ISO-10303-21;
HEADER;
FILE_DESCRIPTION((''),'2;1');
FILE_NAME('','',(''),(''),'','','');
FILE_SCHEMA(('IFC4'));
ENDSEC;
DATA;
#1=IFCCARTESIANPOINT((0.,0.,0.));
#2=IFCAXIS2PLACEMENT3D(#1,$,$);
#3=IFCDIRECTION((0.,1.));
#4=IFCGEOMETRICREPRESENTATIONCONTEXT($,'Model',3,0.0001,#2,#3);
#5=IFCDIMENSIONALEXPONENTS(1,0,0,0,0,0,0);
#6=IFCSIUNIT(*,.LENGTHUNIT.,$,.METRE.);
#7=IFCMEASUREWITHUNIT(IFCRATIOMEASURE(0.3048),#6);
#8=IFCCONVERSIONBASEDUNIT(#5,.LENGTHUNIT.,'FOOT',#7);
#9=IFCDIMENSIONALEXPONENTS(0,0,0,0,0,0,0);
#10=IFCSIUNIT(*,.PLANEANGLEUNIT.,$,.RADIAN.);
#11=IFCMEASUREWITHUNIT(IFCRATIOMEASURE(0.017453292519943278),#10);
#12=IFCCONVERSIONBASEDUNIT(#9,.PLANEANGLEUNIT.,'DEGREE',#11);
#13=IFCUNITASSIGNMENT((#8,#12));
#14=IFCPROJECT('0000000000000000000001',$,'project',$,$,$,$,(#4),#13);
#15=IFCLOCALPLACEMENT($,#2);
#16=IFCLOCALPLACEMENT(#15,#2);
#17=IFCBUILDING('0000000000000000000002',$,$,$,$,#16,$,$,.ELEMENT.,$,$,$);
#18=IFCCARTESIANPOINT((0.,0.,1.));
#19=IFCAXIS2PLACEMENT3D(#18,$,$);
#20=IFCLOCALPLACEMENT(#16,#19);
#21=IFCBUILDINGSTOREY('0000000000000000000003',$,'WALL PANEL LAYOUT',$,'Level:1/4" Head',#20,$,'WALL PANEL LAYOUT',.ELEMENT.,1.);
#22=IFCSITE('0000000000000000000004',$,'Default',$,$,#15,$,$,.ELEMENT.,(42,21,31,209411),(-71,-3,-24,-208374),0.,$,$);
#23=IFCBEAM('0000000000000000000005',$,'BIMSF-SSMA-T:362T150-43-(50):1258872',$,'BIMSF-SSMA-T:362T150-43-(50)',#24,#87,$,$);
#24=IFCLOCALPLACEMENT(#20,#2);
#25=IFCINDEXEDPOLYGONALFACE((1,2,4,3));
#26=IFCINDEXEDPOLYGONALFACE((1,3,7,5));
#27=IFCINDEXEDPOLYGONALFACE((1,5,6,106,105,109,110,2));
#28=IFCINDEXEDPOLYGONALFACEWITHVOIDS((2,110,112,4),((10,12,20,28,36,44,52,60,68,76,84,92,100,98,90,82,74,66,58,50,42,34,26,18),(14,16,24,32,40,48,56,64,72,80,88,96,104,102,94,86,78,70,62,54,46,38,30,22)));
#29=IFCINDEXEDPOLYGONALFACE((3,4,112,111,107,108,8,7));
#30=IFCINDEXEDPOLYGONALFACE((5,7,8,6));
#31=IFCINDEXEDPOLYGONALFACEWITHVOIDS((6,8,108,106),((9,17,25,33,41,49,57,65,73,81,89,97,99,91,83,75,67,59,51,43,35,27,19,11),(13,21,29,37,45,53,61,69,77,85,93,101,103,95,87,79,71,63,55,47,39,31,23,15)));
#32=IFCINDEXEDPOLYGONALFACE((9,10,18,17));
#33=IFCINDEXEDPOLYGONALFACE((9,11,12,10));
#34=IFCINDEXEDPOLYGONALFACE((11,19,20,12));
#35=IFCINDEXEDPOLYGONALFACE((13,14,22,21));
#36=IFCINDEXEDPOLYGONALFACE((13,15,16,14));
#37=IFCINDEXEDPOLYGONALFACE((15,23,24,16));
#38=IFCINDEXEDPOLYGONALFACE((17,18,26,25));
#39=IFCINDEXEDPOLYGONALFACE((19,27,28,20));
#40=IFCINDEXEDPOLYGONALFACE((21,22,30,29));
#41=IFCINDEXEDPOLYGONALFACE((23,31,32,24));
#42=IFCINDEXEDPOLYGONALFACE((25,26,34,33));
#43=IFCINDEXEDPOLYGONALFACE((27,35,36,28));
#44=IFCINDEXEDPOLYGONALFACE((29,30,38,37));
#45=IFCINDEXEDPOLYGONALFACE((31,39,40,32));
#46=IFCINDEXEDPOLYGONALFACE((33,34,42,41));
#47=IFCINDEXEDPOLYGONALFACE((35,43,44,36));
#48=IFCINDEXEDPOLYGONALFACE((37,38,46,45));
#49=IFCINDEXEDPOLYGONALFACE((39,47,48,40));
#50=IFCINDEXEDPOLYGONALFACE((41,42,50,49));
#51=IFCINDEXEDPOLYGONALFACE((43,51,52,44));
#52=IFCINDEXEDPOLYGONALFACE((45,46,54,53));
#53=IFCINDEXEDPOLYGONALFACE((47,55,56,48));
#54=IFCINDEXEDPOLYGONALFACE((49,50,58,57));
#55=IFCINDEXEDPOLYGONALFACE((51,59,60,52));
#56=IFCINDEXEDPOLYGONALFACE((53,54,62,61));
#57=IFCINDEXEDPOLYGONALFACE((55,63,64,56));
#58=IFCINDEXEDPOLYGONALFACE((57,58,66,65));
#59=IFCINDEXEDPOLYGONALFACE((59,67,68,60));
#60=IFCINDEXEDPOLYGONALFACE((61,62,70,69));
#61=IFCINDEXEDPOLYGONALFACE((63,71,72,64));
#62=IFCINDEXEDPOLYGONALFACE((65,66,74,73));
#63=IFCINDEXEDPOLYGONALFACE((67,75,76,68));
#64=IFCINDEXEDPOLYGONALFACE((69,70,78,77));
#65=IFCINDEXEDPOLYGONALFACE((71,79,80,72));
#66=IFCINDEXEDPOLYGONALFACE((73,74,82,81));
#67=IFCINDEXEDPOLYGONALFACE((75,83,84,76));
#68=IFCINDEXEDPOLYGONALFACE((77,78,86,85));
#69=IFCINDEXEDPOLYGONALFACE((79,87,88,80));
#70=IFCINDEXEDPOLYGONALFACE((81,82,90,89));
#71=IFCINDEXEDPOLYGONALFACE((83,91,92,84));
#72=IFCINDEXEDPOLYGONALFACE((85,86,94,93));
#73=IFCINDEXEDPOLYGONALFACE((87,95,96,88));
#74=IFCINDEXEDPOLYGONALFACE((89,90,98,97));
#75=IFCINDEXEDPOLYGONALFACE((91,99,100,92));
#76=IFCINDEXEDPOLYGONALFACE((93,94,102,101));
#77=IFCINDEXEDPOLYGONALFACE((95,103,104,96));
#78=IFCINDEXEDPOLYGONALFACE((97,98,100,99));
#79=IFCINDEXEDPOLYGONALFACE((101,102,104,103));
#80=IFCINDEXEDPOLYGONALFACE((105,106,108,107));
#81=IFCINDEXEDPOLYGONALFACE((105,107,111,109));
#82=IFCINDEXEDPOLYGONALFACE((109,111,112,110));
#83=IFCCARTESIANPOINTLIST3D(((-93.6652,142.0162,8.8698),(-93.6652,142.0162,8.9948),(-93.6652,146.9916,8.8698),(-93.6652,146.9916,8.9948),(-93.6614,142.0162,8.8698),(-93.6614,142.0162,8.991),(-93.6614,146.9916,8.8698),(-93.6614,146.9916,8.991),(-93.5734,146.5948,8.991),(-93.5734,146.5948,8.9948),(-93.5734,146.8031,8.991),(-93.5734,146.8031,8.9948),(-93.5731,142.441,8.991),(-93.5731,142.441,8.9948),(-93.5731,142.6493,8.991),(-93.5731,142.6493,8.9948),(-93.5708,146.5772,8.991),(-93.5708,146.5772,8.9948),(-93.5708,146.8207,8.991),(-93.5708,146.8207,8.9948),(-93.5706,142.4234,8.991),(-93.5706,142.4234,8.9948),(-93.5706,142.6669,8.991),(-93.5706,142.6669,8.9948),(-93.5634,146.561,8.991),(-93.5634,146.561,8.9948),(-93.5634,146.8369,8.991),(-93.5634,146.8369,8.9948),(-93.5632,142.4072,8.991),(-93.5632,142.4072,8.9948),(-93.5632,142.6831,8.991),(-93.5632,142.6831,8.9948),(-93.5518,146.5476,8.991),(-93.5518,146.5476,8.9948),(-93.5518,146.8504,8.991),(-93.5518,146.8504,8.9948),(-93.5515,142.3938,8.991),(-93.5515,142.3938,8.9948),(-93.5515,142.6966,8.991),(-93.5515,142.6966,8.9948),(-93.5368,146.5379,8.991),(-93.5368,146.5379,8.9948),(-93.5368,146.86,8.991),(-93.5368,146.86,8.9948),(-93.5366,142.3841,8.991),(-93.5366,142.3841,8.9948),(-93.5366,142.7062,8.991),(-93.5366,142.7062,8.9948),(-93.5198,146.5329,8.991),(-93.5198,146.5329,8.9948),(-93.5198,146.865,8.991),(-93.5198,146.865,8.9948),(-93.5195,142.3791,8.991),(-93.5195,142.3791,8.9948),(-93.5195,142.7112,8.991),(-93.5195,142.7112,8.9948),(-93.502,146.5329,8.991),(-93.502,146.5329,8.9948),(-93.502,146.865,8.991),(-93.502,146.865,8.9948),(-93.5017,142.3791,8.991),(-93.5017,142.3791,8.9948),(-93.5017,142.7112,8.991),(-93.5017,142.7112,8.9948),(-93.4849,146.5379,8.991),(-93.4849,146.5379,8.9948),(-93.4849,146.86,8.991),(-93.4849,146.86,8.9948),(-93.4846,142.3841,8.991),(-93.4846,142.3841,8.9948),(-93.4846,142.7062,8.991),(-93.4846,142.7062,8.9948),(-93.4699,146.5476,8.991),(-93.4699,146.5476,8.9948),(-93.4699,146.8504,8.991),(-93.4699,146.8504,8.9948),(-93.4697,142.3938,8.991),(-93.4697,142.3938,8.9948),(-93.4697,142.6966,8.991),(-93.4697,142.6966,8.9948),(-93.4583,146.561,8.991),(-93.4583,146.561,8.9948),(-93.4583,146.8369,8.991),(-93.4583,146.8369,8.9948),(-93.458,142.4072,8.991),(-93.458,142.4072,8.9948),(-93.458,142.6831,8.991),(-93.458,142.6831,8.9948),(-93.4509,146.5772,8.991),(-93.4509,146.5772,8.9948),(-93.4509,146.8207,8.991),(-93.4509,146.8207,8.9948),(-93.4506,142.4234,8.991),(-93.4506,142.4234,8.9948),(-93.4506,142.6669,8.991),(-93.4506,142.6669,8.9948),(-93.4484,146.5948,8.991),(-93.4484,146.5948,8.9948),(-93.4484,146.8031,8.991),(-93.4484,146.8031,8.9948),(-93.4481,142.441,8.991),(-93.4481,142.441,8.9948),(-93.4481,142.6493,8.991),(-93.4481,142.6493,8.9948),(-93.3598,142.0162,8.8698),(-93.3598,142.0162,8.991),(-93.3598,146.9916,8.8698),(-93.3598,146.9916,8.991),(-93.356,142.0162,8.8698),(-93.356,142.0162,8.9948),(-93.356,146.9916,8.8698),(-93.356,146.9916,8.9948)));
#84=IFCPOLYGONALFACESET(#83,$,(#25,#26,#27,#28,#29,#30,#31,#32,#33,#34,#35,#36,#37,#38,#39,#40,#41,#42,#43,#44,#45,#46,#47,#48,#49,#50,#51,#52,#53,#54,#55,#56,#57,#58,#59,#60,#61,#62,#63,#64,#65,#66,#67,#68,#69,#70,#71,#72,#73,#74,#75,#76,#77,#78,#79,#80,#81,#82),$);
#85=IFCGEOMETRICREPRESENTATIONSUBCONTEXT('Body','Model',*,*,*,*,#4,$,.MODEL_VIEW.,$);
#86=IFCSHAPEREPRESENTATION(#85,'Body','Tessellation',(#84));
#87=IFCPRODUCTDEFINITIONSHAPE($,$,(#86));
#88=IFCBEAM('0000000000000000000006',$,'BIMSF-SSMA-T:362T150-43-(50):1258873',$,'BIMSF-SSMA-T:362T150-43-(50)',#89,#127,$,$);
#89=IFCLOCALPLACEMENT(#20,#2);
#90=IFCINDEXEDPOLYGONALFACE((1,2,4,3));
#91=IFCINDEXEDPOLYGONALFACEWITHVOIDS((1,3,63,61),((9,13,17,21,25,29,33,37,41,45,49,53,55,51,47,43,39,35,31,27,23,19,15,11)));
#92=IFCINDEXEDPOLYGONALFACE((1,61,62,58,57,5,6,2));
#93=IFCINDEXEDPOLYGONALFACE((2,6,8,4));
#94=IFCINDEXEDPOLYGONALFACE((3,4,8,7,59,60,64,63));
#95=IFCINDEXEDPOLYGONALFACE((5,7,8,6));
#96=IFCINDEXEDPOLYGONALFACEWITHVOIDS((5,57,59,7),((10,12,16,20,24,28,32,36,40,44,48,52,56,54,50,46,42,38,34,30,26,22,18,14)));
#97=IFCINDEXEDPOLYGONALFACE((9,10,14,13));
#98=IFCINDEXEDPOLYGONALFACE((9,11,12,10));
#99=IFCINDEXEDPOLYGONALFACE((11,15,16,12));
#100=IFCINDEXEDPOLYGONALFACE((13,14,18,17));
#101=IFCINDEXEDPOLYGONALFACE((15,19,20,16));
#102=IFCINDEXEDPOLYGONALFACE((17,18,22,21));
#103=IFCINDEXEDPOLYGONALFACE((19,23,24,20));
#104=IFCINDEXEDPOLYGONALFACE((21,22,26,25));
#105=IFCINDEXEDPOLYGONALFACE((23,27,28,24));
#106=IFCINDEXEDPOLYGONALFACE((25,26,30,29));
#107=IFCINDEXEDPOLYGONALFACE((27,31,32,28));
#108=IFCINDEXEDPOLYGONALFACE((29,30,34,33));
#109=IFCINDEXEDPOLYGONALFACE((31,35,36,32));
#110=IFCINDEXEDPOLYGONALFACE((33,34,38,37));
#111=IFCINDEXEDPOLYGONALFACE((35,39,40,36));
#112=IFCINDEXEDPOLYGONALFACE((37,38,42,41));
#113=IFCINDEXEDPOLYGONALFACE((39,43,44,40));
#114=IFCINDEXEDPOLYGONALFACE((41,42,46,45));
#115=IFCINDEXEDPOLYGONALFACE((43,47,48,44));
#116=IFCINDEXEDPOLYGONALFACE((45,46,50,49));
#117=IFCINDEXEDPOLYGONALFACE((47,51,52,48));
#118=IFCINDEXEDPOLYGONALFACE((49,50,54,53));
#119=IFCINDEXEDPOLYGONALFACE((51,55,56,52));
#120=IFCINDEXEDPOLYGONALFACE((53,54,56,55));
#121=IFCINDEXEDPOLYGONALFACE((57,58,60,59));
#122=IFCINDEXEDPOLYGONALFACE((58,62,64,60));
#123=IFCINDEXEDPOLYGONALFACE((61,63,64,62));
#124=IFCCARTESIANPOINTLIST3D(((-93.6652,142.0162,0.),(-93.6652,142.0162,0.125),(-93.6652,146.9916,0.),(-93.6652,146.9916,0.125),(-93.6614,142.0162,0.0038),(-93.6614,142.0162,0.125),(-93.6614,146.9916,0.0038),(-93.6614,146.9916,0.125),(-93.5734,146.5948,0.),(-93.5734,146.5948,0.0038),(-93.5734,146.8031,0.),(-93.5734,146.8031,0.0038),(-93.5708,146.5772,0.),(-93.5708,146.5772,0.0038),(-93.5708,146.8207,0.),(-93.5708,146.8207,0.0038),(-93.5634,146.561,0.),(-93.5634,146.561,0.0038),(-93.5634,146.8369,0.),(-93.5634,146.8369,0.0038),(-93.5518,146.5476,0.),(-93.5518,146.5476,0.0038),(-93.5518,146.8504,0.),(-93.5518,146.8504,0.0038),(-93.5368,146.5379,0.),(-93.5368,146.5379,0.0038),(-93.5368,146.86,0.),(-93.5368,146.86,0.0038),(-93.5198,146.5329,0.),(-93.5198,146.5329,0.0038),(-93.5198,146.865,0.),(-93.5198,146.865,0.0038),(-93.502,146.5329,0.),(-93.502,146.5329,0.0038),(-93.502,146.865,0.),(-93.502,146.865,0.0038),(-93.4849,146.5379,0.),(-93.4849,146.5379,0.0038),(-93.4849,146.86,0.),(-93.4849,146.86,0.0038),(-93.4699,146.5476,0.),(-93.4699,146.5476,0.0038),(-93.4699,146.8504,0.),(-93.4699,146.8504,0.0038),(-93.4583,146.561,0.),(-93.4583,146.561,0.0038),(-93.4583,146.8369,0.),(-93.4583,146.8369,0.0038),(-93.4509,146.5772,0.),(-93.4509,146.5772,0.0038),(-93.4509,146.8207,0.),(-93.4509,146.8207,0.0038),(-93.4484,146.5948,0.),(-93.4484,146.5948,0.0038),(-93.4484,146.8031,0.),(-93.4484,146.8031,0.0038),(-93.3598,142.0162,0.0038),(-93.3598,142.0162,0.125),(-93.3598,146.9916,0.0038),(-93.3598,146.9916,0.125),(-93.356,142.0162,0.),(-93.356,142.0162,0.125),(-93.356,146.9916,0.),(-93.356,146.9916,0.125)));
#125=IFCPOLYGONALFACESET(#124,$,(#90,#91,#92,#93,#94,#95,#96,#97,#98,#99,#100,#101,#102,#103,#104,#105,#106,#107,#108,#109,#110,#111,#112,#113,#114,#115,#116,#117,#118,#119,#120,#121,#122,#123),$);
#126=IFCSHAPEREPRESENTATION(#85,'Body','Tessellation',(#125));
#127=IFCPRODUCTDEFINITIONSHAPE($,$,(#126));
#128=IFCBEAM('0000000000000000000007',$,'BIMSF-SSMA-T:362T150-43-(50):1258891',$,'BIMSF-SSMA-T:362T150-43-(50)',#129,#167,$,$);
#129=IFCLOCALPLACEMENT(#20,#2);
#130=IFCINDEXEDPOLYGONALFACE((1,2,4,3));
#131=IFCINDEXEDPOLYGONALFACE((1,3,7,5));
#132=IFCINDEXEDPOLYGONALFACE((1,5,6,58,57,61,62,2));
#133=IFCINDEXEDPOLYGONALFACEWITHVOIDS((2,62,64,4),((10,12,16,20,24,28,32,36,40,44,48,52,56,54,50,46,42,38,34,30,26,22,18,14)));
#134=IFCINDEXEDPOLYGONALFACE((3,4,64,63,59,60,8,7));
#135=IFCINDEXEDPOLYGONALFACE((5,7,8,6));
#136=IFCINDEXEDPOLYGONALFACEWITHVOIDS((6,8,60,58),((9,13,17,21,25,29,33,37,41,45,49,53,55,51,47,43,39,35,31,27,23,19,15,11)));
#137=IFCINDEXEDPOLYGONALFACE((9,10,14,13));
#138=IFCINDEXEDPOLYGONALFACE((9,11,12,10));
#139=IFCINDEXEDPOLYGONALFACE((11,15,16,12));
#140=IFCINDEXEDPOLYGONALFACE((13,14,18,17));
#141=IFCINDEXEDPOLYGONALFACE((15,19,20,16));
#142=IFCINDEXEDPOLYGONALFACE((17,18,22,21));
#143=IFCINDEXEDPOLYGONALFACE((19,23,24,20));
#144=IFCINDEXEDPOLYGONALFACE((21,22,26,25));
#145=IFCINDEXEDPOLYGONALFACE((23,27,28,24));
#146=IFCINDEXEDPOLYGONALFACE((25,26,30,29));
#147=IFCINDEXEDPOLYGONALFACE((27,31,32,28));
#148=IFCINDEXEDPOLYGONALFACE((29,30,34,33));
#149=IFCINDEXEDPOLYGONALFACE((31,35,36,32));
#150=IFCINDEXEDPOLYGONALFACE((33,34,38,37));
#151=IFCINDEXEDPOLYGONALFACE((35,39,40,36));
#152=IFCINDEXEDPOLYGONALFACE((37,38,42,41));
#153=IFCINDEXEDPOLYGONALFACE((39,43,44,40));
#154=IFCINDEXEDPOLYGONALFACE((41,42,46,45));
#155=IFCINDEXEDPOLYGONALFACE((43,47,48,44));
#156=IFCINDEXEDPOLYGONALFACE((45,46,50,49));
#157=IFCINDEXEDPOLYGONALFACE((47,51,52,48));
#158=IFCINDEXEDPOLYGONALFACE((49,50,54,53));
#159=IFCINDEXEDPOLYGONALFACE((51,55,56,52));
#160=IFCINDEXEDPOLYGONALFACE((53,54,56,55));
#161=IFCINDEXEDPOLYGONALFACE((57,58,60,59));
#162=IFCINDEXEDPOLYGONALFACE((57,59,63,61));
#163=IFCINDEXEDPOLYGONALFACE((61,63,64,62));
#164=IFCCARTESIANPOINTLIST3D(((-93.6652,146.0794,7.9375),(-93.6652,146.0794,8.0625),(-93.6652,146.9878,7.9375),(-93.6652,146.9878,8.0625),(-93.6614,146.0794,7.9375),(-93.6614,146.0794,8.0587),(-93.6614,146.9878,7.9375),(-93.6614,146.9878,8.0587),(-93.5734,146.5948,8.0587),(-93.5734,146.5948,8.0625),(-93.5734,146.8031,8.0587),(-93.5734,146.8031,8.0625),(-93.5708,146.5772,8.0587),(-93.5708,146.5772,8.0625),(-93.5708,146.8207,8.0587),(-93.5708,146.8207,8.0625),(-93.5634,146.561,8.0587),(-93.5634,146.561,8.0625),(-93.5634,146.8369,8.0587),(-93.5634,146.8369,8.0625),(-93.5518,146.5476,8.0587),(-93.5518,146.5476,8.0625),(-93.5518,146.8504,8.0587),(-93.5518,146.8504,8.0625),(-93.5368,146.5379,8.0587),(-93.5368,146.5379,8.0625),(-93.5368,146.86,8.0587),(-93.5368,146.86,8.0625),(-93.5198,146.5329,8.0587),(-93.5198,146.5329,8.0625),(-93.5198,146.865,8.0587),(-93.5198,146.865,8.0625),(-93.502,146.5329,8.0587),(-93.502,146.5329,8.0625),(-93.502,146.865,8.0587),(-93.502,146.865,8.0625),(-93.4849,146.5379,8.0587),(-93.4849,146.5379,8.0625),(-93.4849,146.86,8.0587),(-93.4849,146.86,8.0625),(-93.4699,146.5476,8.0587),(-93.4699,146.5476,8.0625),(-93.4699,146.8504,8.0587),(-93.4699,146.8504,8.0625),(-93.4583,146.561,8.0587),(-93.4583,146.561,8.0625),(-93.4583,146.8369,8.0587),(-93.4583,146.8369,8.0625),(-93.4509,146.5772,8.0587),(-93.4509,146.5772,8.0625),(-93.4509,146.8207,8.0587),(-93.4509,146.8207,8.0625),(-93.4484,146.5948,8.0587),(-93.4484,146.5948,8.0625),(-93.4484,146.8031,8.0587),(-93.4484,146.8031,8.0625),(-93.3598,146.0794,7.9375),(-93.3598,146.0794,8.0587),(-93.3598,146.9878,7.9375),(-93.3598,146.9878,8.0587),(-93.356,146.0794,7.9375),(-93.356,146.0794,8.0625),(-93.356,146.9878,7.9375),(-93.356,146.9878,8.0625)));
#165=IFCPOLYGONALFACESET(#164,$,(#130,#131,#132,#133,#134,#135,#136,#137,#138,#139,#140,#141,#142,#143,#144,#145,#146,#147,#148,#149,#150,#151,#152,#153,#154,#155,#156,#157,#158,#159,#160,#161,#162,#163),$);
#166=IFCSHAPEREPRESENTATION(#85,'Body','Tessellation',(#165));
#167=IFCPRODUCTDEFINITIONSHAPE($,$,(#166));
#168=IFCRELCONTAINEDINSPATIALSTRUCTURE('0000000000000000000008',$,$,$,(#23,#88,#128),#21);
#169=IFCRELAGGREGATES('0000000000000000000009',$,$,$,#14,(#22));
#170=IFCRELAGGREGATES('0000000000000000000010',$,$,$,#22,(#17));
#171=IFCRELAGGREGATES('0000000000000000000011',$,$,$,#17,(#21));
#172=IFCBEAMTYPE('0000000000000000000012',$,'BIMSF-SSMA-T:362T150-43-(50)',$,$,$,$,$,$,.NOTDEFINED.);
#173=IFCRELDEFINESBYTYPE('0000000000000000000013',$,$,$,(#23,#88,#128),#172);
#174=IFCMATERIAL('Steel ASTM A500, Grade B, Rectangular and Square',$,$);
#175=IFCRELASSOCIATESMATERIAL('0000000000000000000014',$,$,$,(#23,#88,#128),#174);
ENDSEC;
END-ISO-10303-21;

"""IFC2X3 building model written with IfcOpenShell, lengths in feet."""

from ifc_helpers import new_model, entity, si_unit, converted_unit, direction, frame, frame_2d, origin, place, context, subcontext, project, spatial, polyline, circle_curve, parameter, trimmed, segment, composite_curve, outline, extrude, boolean, material, type_object, element, save


model = new_model("IFC2X3")

# Units and contexts
model_context = context("Model", 3, precision=0.0001, world=origin(), true_north=direction((0.0, 1.0)))
body_context = subcontext(model_context, "Body", "Model", "MODEL_VIEW")
ifc_project = project(units=[converted_unit("LENGTHUNIT", "FOOT", entity("IfcRatioMeasure", 0.3048), si_unit("LENGTHUNIT", "METRE"), dimensions=[1, 0, 0, 0, 0, 0, 0]), converted_unit("PLANEANGLEUNIT", "DEGREE", entity("IfcRatioMeasure", 0.017453292519943278), si_unit("PLANEANGLEUNIT", "RADIAN"), dimensions=[0, 0, 0, 0, 0, 0, 0])], contexts=[model_context])

# Site, building, storey
site_placement = place(None, origin())
site = spatial("IfcSite", under=ifc_project, at=site_placement, Name="Default", CompositionType="ELEMENT", RefLatitude=(42, 21, 31, 209411), RefLongitude=(-71, -3, -24, -208374), RefElevation=0.0)
building_placement = place(site_placement, origin())
building = spatial("IfcBuilding", under=site, at=building_placement, CompositionType="ELEMENT")
storey_placement = place(building_placement, frame((0.0, 0.0, 1.0)))
storey = spatial("IfcBuildingStorey", under=building, at=storey_placement, Name="WALL PANEL LAYOUT", ObjectType="Level:1/4\" Head", LongName="WALL PANEL LAYOUT", CompositionType="ELEMENT", Elevation=1.0)

# Beams
ifc_material = material(Name="Steel ASTM A500, Grade B, Rectangular and Square")
beam_type_1 = type_object("IfcBeamType", Name="BIMSF-SSMA-T:362T150-43-(50)", PredefinedType="NOTDEFINED")
beam_1_placement = place(storey_placement, frame((-93.5106, 146.9916, 8.9323), z_axis=(0.0, 0.0, 1.0), x_axis=(0.0, -1.0, 0.0)))
element("IfcBeam", 1, at=beam_1_placement, inside=storey, type_object=beam_type_1, material=ifc_material, Name="BIMSF-SSMA-T:362T150-43-(50):1258872", ObjectType="BIMSF-SSMA-T:362T150-43-(50)", context=body_context, shape_type="SweptSolid", body=[
    boolean("DIFFERENCE", boolean("DIFFERENCE", extrude(outline(polyline([(-0.0634, -0.1546), (0.0616, -0.1546), (0.0616, -0.1508), (-0.0597, -0.1508), (-0.0597, 0.1508), (0.0616, 0.1508), (0.0616, 0.1546), (-0.0634, 0.1546), (-0.0634, -0.1546)])), frame((0.0, 0.0, -0.0009), z_axis=(1.0, 0.0, 0.0), x_axis=(0.0, 0.0, -1.0)), (0.0, 0.0, 1.0), 4.9754), extrude(outline(composite_curve([segment(trimmed(circle_curve(frame_2d((0.1042, 0.0), x_axis=(1.0, 0.0)), 0.0625), [parameter(270.0)], [parameter(90.0)], True, "PARAMETER"), True, "CONTINUOUS"), segment(polyline([(0.1042, 0.0625), (-0.1042, 0.0625)]), True, "CONTINUOUS"), segment(trimmed(circle_curve(frame_2d((-0.1042, 0.0), x_axis=(1.0, 0.0)), 0.0625), [parameter(90.0)], [parameter(270.0)], True, "PARAMETER"), True, "CONTINUOUS"), segment(polyline([(-0.1042, -0.0625), (0.1042, -0.0625)]), True, "CONTINUOUS")], self_intersect=False)), frame((4.4464, 0.0, 0.0587)), (0.0, 0.0, 1.0), 0.0038)), extrude(outline(composite_curve([segment(trimmed(circle_curve(frame_2d((-0.1042, 0.0), x_axis=(1.0, 0.0)), 0.0625), [parameter(90.0)], [parameter(270.0)], True, "PARAMETER"), True, "CONTINUOUS"), segment(polyline([(-0.1042, -0.0625), (0.1042, -0.0625)]), True, "CONTINUOUS"), segment(trimmed(circle_curve(frame_2d((0.1042, 0.0), x_axis=(1.0, 0.0)), 0.0625), [parameter(270.0)], [parameter(90.0)], True, "PARAMETER"), True, "CONTINUOUS"), segment(polyline([(0.1042, 0.0625), (-0.1042, 0.0625)]), True, "CONTINUOUS")], self_intersect=False)), frame((0.2926, -0.0003, 0.0587)), (0.0, 0.0, 1.0), 0.0038)),
])
beam_2_placement = place(storey_placement, frame((-93.5106, 146.9916, 0.0625), z_axis=(0.0, 0.0, 1.0), x_axis=(0.0, -1.0, 0.0)))
element("IfcBeam", 2, at=beam_2_placement, inside=storey, type_object=beam_type_1, material=ifc_material, Name="BIMSF-SSMA-T:362T150-43-(50):1258873", ObjectType="BIMSF-SSMA-T:362T150-43-(50)", context=body_context, shape_type="SweptSolid", body=[
    boolean("DIFFERENCE", extrude(outline(polyline([(-0.0616, -0.1546), (0.0634, -0.1546), (0.0634, 0.1546), (-0.0616, 0.1546), (-0.0616, 0.1508), (0.0597, 0.1508), (0.0597, -0.1508), (-0.0616, -0.1508), (-0.0616, -0.1546)])), frame((0.0, 0.0, 0.0009), z_axis=(1.0, 0.0, 0.0), x_axis=(0.0, 0.0, -1.0)), (0.0, 0.0, 1.0), 4.9754), extrude(outline(composite_curve([segment(polyline([(-0.1042, -0.0625), (0.1042, -0.0625)]), True, "CONTINUOUS"), segment(trimmed(circle_curve(frame_2d((0.1042, 0.0), x_axis=(1.0, 0.0)), 0.0625), [parameter(270.0)], [parameter(90.0)], True, "PARAMETER"), True, "CONTINUOUS"), segment(polyline([(0.1042, 0.0625), (-0.1042, 0.0625)]), True, "CONTINUOUS"), segment(trimmed(circle_curve(frame_2d((-0.1042, 0.0), x_axis=(1.0, 0.0)), 0.0625), [parameter(90.0)], [parameter(270.0)], True, "PARAMETER"), True, "CONTINUOUS")], self_intersect=False)), frame((0.2926, -0.0003, -0.0587), z_axis=(0.0, 0.0, -1.0), x_axis=(1.0, 0.0, 0.0)), (0.0, 0.0, 1.0), 0.0038)),
])
beam_3_placement = place(storey_placement, frame((-93.5106, 146.9878, 8.0), z_axis=(0.0, 0.0, 1.0), x_axis=(0.0, -1.0, 0.0)))
element("IfcBeam", 3, at=beam_3_placement, inside=storey, type_object=beam_type_1, material=ifc_material, Name="BIMSF-SSMA-T:362T150-43-(50):1258891", ObjectType="BIMSF-SSMA-T:362T150-43-(50)", context=body_context, shape_type="SweptSolid", body=[
    boolean("DIFFERENCE", extrude(outline(polyline([(-0.0634, -0.1546), (0.0616, -0.1546), (0.0616, -0.1508), (-0.0597, -0.1508), (-0.0597, 0.1508), (0.0616, 0.1508), (0.0616, 0.1546), (-0.0634, 0.1546), (-0.0634, -0.1546)])), frame((0.0, 0.0, -0.0009), z_axis=(1.0, 0.0, 0.0), x_axis=(0.0, 0.0, -1.0)), (0.0, 0.0, 1.0), 0.9084), extrude(outline(composite_curve([segment(trimmed(circle_curve(frame_2d((-0.1042, 0.0), x_axis=(1.0, 0.0)), 0.0625), [parameter(90.0)], [parameter(270.0)], True, "PARAMETER"), True, "CONTINUOUS"), segment(polyline([(-0.1042, -0.0625), (0.1042, -0.0625)]), True, "CONTINUOUS"), segment(trimmed(circle_curve(frame_2d((0.1042, 0.0), x_axis=(1.0, 0.0)), 0.0625), [parameter(270.0)], [parameter(90.0)], True, "PARAMETER"), True, "CONTINUOUS"), segment(polyline([(0.1042, 0.0625), (-0.1042, 0.0625)]), True, "CONTINUOUS")], self_intersect=False)), frame((0.2888, -0.0003, 0.0587)), (0.0, 0.0, 1.0), 0.0038)),
])

save(model, "model.ifc")
